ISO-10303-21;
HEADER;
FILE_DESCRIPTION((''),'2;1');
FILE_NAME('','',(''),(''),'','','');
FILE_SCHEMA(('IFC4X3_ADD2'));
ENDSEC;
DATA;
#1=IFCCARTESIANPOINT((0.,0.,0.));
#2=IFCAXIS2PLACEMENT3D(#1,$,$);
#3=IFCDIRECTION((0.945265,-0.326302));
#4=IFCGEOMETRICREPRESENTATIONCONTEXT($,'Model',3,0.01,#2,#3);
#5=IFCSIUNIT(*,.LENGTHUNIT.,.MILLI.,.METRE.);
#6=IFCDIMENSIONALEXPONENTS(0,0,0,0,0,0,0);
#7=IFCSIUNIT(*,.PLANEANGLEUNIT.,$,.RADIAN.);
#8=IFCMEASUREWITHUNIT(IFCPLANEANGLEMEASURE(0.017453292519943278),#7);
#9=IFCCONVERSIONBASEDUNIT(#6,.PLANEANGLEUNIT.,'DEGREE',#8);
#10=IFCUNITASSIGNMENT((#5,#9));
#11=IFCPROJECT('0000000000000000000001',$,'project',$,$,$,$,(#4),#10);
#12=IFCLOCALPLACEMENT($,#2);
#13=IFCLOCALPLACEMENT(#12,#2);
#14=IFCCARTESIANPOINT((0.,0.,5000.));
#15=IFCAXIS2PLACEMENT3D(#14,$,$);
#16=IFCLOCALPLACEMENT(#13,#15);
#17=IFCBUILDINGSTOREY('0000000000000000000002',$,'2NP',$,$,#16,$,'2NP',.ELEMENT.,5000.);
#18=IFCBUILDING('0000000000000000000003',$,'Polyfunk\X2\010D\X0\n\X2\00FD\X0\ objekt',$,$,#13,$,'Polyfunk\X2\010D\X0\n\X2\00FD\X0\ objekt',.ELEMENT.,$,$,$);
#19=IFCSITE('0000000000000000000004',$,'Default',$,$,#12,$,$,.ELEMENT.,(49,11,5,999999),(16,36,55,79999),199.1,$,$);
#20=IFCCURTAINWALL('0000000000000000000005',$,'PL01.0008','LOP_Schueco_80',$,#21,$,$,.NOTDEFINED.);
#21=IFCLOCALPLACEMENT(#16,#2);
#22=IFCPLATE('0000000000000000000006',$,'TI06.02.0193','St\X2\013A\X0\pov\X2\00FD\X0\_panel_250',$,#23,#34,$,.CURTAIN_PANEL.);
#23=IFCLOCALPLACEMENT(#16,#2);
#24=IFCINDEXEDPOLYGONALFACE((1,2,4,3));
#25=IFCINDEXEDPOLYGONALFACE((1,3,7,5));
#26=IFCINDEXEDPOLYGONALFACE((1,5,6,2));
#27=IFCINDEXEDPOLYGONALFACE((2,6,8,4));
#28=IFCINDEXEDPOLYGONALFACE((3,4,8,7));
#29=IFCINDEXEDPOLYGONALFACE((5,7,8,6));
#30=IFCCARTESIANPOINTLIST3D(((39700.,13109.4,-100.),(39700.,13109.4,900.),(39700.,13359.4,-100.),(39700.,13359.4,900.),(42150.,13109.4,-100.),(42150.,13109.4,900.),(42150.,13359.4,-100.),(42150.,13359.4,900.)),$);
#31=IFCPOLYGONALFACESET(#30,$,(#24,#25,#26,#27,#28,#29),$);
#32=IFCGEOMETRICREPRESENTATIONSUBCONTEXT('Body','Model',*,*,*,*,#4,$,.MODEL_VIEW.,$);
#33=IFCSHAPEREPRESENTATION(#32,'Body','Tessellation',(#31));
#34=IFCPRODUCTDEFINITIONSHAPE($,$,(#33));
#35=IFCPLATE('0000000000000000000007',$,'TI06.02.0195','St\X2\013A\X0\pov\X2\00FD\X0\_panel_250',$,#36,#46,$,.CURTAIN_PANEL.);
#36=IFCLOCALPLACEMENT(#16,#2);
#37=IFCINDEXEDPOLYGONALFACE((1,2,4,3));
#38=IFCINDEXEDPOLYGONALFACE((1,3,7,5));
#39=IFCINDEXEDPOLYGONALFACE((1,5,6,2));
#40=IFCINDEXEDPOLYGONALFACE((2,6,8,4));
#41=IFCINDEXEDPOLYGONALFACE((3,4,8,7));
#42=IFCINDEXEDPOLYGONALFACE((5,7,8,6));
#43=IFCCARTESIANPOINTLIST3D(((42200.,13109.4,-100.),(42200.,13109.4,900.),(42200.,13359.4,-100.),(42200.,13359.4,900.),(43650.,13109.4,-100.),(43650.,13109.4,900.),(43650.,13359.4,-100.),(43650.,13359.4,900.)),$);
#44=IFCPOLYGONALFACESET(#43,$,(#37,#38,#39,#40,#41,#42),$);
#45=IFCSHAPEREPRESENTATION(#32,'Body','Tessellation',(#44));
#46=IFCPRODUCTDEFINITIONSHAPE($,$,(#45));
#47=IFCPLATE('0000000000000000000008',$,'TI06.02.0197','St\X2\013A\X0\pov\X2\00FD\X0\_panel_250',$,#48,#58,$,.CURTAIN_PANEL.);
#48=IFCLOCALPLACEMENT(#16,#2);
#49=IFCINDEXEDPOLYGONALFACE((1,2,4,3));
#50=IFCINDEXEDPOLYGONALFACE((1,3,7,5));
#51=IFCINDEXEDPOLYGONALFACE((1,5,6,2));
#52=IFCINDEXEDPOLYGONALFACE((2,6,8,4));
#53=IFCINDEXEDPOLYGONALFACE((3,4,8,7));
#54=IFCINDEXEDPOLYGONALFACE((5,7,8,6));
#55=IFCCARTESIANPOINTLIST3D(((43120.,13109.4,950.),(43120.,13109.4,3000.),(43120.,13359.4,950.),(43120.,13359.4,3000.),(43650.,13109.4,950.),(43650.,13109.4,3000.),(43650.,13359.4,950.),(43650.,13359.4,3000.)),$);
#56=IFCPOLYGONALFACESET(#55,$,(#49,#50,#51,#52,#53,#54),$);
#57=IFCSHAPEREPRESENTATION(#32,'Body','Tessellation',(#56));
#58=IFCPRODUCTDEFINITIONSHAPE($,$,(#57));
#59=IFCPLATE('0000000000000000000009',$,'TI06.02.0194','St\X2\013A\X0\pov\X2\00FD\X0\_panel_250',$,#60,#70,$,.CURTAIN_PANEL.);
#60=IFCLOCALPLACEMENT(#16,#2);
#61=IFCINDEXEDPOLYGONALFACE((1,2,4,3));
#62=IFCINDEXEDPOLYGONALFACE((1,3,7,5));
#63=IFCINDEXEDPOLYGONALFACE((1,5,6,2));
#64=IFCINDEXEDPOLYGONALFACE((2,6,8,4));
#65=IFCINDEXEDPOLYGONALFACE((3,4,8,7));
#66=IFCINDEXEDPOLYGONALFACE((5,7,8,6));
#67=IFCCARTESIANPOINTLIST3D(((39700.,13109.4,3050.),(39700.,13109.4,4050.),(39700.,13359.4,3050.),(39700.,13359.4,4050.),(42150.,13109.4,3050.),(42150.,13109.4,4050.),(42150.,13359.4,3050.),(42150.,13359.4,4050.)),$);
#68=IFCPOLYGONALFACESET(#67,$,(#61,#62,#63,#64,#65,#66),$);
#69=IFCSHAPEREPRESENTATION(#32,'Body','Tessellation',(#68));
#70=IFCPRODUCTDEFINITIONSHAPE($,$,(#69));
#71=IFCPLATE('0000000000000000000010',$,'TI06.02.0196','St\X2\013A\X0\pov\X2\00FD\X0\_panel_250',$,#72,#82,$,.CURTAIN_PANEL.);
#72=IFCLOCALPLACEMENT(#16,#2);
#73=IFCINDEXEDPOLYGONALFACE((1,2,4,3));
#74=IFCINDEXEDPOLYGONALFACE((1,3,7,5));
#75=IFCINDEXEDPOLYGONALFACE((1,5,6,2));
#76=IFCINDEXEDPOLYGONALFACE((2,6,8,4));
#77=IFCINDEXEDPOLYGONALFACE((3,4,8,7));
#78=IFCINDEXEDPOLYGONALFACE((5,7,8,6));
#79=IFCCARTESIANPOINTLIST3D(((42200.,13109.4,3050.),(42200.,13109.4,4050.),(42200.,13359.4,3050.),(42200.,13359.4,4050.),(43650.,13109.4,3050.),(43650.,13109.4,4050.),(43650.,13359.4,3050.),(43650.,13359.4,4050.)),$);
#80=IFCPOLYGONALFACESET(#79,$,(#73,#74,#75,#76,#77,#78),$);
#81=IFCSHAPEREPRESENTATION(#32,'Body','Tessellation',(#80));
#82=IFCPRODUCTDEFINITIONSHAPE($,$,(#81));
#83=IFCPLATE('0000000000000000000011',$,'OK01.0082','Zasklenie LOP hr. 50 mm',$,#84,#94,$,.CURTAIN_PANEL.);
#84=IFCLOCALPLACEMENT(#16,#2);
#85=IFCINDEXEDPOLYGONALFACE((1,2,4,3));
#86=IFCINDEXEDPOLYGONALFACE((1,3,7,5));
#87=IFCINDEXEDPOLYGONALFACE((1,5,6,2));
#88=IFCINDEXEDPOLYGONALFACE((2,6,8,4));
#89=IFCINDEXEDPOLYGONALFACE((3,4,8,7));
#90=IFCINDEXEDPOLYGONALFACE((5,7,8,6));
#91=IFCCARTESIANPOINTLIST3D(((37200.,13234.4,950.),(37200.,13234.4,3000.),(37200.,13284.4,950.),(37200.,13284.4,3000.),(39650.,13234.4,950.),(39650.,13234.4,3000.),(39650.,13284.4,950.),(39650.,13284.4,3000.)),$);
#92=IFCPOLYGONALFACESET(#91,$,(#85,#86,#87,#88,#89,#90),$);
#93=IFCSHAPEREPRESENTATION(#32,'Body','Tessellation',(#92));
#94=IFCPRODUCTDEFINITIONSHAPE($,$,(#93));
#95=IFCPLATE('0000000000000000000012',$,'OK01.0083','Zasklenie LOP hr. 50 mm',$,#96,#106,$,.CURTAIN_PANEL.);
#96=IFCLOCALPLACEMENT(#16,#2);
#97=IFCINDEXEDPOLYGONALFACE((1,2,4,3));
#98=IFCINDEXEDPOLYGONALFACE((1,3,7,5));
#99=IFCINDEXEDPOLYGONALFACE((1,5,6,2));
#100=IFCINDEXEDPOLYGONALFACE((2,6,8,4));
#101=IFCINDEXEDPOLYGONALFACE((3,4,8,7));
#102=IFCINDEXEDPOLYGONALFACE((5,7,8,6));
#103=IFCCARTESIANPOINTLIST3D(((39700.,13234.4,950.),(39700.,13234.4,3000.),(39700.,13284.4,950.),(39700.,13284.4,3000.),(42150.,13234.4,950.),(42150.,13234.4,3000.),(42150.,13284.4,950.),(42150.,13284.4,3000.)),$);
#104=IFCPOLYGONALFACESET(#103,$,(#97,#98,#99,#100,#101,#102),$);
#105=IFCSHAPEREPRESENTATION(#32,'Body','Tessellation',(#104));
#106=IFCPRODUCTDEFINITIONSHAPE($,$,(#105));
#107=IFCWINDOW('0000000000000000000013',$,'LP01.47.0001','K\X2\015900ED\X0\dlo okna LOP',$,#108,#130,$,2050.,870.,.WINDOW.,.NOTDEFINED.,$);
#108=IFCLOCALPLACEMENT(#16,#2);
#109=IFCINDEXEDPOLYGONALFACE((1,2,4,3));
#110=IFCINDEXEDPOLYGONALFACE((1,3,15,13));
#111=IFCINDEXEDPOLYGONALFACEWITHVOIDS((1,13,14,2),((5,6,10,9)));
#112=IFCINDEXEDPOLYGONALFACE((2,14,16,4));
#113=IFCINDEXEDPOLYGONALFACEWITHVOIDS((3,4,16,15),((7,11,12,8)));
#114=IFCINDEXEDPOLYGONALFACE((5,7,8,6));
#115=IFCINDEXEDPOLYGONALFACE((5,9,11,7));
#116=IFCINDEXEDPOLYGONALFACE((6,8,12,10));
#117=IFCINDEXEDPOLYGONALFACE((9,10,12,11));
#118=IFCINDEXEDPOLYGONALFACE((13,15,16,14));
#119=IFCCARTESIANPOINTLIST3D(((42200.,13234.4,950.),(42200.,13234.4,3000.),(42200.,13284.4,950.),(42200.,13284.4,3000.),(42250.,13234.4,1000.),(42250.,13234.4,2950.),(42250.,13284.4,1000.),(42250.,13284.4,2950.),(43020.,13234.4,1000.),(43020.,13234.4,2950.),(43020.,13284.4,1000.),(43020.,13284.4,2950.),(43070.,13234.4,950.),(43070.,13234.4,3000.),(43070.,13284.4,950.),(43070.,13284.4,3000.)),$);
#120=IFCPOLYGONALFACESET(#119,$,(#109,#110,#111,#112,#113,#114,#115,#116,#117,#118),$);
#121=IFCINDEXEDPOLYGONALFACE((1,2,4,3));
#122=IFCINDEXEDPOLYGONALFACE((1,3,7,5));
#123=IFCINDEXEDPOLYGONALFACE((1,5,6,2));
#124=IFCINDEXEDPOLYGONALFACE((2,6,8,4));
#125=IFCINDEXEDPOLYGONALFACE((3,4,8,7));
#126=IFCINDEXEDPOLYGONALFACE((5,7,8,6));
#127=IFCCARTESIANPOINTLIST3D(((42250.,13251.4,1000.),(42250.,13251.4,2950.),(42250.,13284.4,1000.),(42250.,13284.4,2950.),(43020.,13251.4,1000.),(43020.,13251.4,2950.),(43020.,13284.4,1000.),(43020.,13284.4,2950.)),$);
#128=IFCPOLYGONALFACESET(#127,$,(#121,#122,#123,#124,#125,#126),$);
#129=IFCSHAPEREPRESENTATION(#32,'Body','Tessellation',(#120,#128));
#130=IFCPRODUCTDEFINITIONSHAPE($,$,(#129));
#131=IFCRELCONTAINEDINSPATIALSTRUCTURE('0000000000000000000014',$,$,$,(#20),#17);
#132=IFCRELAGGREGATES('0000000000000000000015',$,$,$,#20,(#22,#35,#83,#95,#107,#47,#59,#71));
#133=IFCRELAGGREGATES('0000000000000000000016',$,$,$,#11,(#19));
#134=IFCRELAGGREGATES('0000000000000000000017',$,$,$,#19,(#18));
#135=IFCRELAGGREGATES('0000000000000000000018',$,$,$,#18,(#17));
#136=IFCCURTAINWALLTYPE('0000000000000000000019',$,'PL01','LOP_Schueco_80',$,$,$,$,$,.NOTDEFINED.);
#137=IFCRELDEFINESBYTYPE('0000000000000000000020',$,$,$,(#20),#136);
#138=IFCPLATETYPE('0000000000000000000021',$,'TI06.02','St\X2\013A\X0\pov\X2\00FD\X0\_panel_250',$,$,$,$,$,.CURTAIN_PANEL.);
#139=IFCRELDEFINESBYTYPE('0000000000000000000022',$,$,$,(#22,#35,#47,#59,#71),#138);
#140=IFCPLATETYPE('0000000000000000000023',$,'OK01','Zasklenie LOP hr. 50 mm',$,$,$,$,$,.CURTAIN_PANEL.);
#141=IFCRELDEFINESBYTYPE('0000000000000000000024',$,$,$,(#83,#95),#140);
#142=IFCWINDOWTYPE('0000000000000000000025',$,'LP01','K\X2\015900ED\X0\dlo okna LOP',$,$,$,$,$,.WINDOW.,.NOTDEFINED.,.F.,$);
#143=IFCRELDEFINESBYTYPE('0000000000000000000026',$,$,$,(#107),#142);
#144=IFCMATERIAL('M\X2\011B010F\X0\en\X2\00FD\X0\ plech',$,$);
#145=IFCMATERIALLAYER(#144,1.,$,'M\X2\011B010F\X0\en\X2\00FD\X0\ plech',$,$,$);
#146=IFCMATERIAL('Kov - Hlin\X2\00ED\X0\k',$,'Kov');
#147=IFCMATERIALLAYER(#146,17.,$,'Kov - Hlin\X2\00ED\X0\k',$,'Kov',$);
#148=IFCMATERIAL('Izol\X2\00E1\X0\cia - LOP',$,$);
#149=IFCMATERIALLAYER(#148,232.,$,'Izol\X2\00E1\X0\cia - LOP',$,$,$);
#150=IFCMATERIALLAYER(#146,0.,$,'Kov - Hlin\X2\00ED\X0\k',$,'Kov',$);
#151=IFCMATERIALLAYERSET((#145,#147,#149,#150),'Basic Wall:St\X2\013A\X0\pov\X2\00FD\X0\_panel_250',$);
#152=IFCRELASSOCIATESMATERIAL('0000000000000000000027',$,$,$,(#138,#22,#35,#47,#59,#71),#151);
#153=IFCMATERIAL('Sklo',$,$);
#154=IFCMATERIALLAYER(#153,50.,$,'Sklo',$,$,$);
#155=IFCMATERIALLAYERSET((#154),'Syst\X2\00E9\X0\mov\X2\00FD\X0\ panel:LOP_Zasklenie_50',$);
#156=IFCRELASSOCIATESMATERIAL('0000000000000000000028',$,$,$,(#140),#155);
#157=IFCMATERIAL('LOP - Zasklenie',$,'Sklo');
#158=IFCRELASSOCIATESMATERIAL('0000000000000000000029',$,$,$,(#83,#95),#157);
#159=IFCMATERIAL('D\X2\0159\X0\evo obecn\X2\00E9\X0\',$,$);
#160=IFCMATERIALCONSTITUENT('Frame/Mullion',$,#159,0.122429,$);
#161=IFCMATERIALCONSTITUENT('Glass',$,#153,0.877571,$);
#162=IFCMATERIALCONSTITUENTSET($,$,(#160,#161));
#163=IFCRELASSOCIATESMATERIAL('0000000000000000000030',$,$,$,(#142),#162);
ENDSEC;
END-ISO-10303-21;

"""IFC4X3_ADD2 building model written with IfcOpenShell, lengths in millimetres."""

from ifc_helpers import new_model, entity, si_unit, converted_unit, direction, frame, frame_2d, origin, origin_2d_with_axis, place, context, subcontext, project, spatial, polyline, rectangle, outline, extrude, source, transform, mapped, material, layer, layer_set, layer_usage, constituent, constituent_set, type_object, type_shapes, element, aggregate, save


model = new_model("IFC4X3_ADD2")

# Units and contexts
model_context = context("Model", 3, precision=0.01, world=origin(), true_north=direction((0.945265, -0.326302)))
body_context = subcontext(model_context, "Body", "Model", "MODEL_VIEW")
ifc_project = project(units=[si_unit("LENGTHUNIT", "METRE", prefix="MILLI"), converted_unit("PLANEANGLEUNIT", "DEGREE", entity("IfcPlaneAngleMeasure", 0.017453292519943278), si_unit("PLANEANGLEUNIT", "RADIAN"), dimensions=[0, 0, 0, 0, 0, 0, 0])], contexts=[model_context])

# Site, building, storey
site_placement = place(None, origin())
site = spatial("IfcSite", under=ifc_project, at=site_placement, Name="Default", CompositionType="ELEMENT", RefLatitude=(49, 11, 5, 999999), RefLongitude=(16, 36, 55, 79999), RefElevation=199.1)
building_placement = place(site_placement, origin())
building = spatial("IfcBuilding", under=site, at=building_placement, Name="Polyfunkčný objekt", LongName="Polyfunkčný objekt", CompositionType="ELEMENT")
storey_placement = place(building_placement, frame((0.0, 0.0, 5000.0)))
storey = spatial("IfcBuildingStorey", under=building, at=storey_placement, Name="2NP", LongName="2NP", CompositionType="ELEMENT", Elevation=5000.0)

# Curtain wall, plates, window
curtain_wall_type = type_object("IfcCurtainWallType", Name="PL01", Description="LOP_Schueco_80", PredefinedType="NOTDEFINED")
curtain_wall_placement = place(storey_placement, frame((0.0, 0.0, -5000.0)))
curtain_wall = element("IfcCurtainWall", 1, at=curtain_wall_placement, inside=storey, type_object=curtain_wall_type, Name="PL01.0008", Description="LOP_Schueco_80", PredefinedType="NOTDEFINED")
ifc_material_1 = material(Name="Měďený plech")
ifc_layer_1 = layer(ifc_material_1, 1.0, Name="Měďený plech")
ifc_material_2 = material(Name="Kov - Hliník", Category="Kov")
ifc_layer_2 = layer(ifc_material_2, 17.0, Name="Kov - Hliník", Category="Kov")
ifc_material_3 = material(Name="Izolácia - LOP")
ifc_layer_3 = layer(ifc_material_3, 232.0, Name="Izolácia - LOP")
ifc_layer_4 = layer(ifc_material_2, 0.0, Name="Kov - Hliník", Category="Kov")
ifc_layer_set_1 = layer_set([ifc_layer_1, ifc_layer_2, ifc_layer_3, ifc_layer_4], Name="Basic Wall:Stĺpový_panel_250")
ifc_layer_usage_1 = layer_usage(ifc_layer_set_1, "AXIS2", "NEGATIVE", 125.0)
plate_type_1 = type_object("IfcPlateType", Name="TI06.02", Description="Stĺpový_panel_250", PredefinedType="CURTAIN_PANEL", material=ifc_layer_set_1)
plate_1_placement = place(storey_placement, frame((39700.0, 13234.4, -100.0)))
plate_1 = element("IfcPlate", 2, at=plate_1_placement, type_object=plate_type_1, material=ifc_layer_usage_1, Name="TI06.02.0193", Description="Stĺpový_panel_250", PredefinedType="CURTAIN_PANEL", context=body_context, shape_type="SweptSolid", body=[
    extrude(rectangle(XDim=250.0, YDim=2450.0, at=frame_2d((0.0, 0.0), x_axis=(1.0, 0.0))), frame((1225.0, 0.0, 0.0), z_axis=(0.0, 0.0, 1.0), x_axis=(0.0, 1.0, 0.0)), (0.0, 0.0, 1.0), 1000.0),
])
ifc_layer_usage_2 = layer_usage(ifc_layer_set_1, "AXIS2", "NEGATIVE", 125.0)
plate_2_placement = place(storey_placement, frame((42200.0, 13234.4, -100.0)))
plate_2 = element("IfcPlate", 3, at=plate_2_placement, type_object=plate_type_1, material=ifc_layer_usage_2, Name="TI06.02.0195", Description="Stĺpový_panel_250", PredefinedType="CURTAIN_PANEL", context=body_context, shape_type="SweptSolid", body=[
    extrude(rectangle(XDim=250.0, YDim=1450.0, at=frame_2d((0.0, 0.0), x_axis=(1.0, 0.0))), frame((725.0, 0.0, 0.0), z_axis=(0.0, 0.0, 1.0), x_axis=(0.0, 1.0, 0.0)), (0.0, 0.0, 1.0), 1000.0),
])
ifc_layer_usage_3 = layer_usage(ifc_layer_set_1, "AXIS2", "NEGATIVE", 125.0)
plate_3_placement = place(storey_placement, frame((43120.0, 13234.4, 950.0)))
plate_3 = element("IfcPlate", 4, at=plate_3_placement, type_object=plate_type_1, material=ifc_layer_usage_3, Name="TI06.02.0197", Description="Stĺpový_panel_250", PredefinedType="CURTAIN_PANEL", context=body_context, shape_type="SweptSolid", body=[
    extrude(rectangle(XDim=250.0, YDim=530.0, at=frame_2d((0.0, 0.0), x_axis=(1.0, 0.0))), frame((265.0, 0.0, 0.0), z_axis=(0.0, 0.0, 1.0), x_axis=(0.0, 1.0, 0.0)), (0.0, 0.0, 1.0), 2050.0),
])
ifc_layer_usage_4 = layer_usage(ifc_layer_set_1, "AXIS2", "NEGATIVE", 125.0)
plate_4_placement = place(storey_placement, frame((39700.0, 13234.4, 3050.0)))
plate_4 = element("IfcPlate", 5, at=plate_4_placement, type_object=plate_type_1, material=ifc_layer_usage_4, Name="TI06.02.0194", Description="Stĺpový_panel_250", PredefinedType="CURTAIN_PANEL", context=body_context, shape_type="SweptSolid", body=[
    extrude(rectangle(XDim=250.0, YDim=2450.0, at=frame_2d((0.0, 0.0), x_axis=(1.0, 0.0))), frame((1225.0, 0.0, 0.0), z_axis=(0.0, 0.0, 1.0), x_axis=(0.0, 1.0, 0.0)), (0.0, 0.0, 1.0), 1000.0),
])
ifc_layer_usage_5 = layer_usage(ifc_layer_set_1, "AXIS2", "NEGATIVE", 125.0)
plate_5_placement = place(storey_placement, frame((42200.0, 13234.4, 3050.0)))
plate_5 = element("IfcPlate", 6, at=plate_5_placement, type_object=plate_type_1, material=ifc_layer_usage_5, Name="TI06.02.0196", Description="Stĺpový_panel_250", PredefinedType="CURTAIN_PANEL", context=body_context, shape_type="SweptSolid", body=[
    extrude(rectangle(XDim=250.0, YDim=1450.0, at=frame_2d((0.0, 0.0), x_axis=(1.0, 0.0))), frame((725.0, 0.0, 0.0), z_axis=(0.0, 0.0, 1.0), x_axis=(0.0, 1.0, 0.0)), (0.0, 0.0, 1.0), 1000.0),
])
ifc_material_4 = material(Name="LOP - Zasklenie", Category="Sklo")
ifc_material_5 = material(Name="Sklo")
ifc_layer_5 = layer(ifc_material_5, 50.0, Name="Sklo")
ifc_layer_set_2 = layer_set([ifc_layer_5], Name="Systémový panel:LOP_Zasklenie_50")
plate_type_2 = type_object("IfcPlateType", Name="OK01", Description="Zasklenie LOP hr. 50 mm", PredefinedType="CURTAIN_PANEL", material=ifc_layer_set_2)
shared_shape_1 = source(origin(), body_context, "Body", "SweptSolid", [
    extrude(rectangle(XDim=50.0, YDim=2450.0, at=origin_2d_with_axis()), frame((0.0, 25.0, 0.0), z_axis=(0.0, 0.0, 1.0), x_axis=(0.0, 1.0, 0.0)), (0.0, 0.0, 1.0), 2050.0),
])
type_shapes(plate_type_2, [shared_shape_1])
plate_6_placement = place(curtain_wall_placement, frame((38425.0, 13234.4, 5950.0)))
plate_6 = element("IfcPlate", 7, at=plate_6_placement, type_object=plate_type_2, material=ifc_material_4, Name="OK01.0082", Description="Zasklenie LOP hr. 50 mm", PredefinedType="CURTAIN_PANEL", context=body_context, shape_type="MappedRepresentation", body=[
    mapped(shared_shape_1, transform((0.0, 0.0, 0.0), scale=1.0)),
])
plate_7_placement = place(curtain_wall_placement, frame((40925.0, 13234.4, 5950.0)))
plate_7 = element("IfcPlate", 8, at=plate_7_placement, type_object=plate_type_2, material=ifc_material_4, Name="OK01.0083", Description="Zasklenie LOP hr. 50 mm", PredefinedType="CURTAIN_PANEL", context=body_context, shape_type="MappedRepresentation", body=[
    mapped(shared_shape_1, transform((0.0, 0.0, 0.0), scale=1.0)),
])
ifc_material_6 = material(Name="Dřevo obecné")
ifc_constituent_1 = constituent(ifc_material_6, Name="Frame/Mullion", fraction=0.122429)
ifc_constituent_2 = constituent(ifc_material_5, Name="Glass", fraction=0.877571)
ifc_constituent_set = constituent_set(constituents=[ifc_constituent_1, ifc_constituent_2])
window_type = type_object("IfcWindowType", Name="LP01", Description="Křídlo okna LOP", ParameterTakesPrecedence=False, PartitioningType="NOTDEFINED", PredefinedType="WINDOW", material=ifc_constituent_set)
shared_shape_2 = source(origin(), body_context, "Body", "SweptSolid", [
    extrude(outline(polyline([(-1025.0, -435.0), (1025.0, -435.0), (1025.0, 435.0), (-1025.0, 435.0), (-1025.0, -435.0)]), holes=[polyline([(-975.0, -385.0), (-975.0, 385.0), (975.0, 385.0), (975.0, -385.0), (-975.0, -385.0)])]), frame((0.0, 0.0, 1025.0), z_axis=(0.0, 1.0, 0.0), x_axis=(0.0, 0.0, -1.0)), (0.0, 0.0, 1.0), 50.0),
    extrude(rectangle(XDim=33.0, YDim=770.0, at=origin_2d_with_axis()), frame((0.0, 33.5, 50.0), z_axis=(0.0, 0.0, 1.0), x_axis=(0.0, -1.0, 0.0)), (0.0, 0.0, 1.0), 1950.0),
])
type_shapes(window_type, [shared_shape_2])
window_placement = place(curtain_wall_placement, frame((42635.0, 13234.4, 5950.0)))
window = element("IfcWindow", 9, at=window_placement, type_object=window_type, Name="LP01.47.0001", Description="Křídlo okna LOP", OverallHeight=2050.0, OverallWidth=870.0, PartitioningType="NOTDEFINED", PredefinedType="WINDOW", context=body_context, shape_type="MappedRepresentation", body=[
    mapped(shared_shape_2, transform((0.0, 0.0, 0.0), scale=1.0)),
])
aggregate(curtain_wall, [plate_1, plate_2, plate_6, plate_7, window, plate_3, plate_4, plate_5])

save(model, "model.ifc")
